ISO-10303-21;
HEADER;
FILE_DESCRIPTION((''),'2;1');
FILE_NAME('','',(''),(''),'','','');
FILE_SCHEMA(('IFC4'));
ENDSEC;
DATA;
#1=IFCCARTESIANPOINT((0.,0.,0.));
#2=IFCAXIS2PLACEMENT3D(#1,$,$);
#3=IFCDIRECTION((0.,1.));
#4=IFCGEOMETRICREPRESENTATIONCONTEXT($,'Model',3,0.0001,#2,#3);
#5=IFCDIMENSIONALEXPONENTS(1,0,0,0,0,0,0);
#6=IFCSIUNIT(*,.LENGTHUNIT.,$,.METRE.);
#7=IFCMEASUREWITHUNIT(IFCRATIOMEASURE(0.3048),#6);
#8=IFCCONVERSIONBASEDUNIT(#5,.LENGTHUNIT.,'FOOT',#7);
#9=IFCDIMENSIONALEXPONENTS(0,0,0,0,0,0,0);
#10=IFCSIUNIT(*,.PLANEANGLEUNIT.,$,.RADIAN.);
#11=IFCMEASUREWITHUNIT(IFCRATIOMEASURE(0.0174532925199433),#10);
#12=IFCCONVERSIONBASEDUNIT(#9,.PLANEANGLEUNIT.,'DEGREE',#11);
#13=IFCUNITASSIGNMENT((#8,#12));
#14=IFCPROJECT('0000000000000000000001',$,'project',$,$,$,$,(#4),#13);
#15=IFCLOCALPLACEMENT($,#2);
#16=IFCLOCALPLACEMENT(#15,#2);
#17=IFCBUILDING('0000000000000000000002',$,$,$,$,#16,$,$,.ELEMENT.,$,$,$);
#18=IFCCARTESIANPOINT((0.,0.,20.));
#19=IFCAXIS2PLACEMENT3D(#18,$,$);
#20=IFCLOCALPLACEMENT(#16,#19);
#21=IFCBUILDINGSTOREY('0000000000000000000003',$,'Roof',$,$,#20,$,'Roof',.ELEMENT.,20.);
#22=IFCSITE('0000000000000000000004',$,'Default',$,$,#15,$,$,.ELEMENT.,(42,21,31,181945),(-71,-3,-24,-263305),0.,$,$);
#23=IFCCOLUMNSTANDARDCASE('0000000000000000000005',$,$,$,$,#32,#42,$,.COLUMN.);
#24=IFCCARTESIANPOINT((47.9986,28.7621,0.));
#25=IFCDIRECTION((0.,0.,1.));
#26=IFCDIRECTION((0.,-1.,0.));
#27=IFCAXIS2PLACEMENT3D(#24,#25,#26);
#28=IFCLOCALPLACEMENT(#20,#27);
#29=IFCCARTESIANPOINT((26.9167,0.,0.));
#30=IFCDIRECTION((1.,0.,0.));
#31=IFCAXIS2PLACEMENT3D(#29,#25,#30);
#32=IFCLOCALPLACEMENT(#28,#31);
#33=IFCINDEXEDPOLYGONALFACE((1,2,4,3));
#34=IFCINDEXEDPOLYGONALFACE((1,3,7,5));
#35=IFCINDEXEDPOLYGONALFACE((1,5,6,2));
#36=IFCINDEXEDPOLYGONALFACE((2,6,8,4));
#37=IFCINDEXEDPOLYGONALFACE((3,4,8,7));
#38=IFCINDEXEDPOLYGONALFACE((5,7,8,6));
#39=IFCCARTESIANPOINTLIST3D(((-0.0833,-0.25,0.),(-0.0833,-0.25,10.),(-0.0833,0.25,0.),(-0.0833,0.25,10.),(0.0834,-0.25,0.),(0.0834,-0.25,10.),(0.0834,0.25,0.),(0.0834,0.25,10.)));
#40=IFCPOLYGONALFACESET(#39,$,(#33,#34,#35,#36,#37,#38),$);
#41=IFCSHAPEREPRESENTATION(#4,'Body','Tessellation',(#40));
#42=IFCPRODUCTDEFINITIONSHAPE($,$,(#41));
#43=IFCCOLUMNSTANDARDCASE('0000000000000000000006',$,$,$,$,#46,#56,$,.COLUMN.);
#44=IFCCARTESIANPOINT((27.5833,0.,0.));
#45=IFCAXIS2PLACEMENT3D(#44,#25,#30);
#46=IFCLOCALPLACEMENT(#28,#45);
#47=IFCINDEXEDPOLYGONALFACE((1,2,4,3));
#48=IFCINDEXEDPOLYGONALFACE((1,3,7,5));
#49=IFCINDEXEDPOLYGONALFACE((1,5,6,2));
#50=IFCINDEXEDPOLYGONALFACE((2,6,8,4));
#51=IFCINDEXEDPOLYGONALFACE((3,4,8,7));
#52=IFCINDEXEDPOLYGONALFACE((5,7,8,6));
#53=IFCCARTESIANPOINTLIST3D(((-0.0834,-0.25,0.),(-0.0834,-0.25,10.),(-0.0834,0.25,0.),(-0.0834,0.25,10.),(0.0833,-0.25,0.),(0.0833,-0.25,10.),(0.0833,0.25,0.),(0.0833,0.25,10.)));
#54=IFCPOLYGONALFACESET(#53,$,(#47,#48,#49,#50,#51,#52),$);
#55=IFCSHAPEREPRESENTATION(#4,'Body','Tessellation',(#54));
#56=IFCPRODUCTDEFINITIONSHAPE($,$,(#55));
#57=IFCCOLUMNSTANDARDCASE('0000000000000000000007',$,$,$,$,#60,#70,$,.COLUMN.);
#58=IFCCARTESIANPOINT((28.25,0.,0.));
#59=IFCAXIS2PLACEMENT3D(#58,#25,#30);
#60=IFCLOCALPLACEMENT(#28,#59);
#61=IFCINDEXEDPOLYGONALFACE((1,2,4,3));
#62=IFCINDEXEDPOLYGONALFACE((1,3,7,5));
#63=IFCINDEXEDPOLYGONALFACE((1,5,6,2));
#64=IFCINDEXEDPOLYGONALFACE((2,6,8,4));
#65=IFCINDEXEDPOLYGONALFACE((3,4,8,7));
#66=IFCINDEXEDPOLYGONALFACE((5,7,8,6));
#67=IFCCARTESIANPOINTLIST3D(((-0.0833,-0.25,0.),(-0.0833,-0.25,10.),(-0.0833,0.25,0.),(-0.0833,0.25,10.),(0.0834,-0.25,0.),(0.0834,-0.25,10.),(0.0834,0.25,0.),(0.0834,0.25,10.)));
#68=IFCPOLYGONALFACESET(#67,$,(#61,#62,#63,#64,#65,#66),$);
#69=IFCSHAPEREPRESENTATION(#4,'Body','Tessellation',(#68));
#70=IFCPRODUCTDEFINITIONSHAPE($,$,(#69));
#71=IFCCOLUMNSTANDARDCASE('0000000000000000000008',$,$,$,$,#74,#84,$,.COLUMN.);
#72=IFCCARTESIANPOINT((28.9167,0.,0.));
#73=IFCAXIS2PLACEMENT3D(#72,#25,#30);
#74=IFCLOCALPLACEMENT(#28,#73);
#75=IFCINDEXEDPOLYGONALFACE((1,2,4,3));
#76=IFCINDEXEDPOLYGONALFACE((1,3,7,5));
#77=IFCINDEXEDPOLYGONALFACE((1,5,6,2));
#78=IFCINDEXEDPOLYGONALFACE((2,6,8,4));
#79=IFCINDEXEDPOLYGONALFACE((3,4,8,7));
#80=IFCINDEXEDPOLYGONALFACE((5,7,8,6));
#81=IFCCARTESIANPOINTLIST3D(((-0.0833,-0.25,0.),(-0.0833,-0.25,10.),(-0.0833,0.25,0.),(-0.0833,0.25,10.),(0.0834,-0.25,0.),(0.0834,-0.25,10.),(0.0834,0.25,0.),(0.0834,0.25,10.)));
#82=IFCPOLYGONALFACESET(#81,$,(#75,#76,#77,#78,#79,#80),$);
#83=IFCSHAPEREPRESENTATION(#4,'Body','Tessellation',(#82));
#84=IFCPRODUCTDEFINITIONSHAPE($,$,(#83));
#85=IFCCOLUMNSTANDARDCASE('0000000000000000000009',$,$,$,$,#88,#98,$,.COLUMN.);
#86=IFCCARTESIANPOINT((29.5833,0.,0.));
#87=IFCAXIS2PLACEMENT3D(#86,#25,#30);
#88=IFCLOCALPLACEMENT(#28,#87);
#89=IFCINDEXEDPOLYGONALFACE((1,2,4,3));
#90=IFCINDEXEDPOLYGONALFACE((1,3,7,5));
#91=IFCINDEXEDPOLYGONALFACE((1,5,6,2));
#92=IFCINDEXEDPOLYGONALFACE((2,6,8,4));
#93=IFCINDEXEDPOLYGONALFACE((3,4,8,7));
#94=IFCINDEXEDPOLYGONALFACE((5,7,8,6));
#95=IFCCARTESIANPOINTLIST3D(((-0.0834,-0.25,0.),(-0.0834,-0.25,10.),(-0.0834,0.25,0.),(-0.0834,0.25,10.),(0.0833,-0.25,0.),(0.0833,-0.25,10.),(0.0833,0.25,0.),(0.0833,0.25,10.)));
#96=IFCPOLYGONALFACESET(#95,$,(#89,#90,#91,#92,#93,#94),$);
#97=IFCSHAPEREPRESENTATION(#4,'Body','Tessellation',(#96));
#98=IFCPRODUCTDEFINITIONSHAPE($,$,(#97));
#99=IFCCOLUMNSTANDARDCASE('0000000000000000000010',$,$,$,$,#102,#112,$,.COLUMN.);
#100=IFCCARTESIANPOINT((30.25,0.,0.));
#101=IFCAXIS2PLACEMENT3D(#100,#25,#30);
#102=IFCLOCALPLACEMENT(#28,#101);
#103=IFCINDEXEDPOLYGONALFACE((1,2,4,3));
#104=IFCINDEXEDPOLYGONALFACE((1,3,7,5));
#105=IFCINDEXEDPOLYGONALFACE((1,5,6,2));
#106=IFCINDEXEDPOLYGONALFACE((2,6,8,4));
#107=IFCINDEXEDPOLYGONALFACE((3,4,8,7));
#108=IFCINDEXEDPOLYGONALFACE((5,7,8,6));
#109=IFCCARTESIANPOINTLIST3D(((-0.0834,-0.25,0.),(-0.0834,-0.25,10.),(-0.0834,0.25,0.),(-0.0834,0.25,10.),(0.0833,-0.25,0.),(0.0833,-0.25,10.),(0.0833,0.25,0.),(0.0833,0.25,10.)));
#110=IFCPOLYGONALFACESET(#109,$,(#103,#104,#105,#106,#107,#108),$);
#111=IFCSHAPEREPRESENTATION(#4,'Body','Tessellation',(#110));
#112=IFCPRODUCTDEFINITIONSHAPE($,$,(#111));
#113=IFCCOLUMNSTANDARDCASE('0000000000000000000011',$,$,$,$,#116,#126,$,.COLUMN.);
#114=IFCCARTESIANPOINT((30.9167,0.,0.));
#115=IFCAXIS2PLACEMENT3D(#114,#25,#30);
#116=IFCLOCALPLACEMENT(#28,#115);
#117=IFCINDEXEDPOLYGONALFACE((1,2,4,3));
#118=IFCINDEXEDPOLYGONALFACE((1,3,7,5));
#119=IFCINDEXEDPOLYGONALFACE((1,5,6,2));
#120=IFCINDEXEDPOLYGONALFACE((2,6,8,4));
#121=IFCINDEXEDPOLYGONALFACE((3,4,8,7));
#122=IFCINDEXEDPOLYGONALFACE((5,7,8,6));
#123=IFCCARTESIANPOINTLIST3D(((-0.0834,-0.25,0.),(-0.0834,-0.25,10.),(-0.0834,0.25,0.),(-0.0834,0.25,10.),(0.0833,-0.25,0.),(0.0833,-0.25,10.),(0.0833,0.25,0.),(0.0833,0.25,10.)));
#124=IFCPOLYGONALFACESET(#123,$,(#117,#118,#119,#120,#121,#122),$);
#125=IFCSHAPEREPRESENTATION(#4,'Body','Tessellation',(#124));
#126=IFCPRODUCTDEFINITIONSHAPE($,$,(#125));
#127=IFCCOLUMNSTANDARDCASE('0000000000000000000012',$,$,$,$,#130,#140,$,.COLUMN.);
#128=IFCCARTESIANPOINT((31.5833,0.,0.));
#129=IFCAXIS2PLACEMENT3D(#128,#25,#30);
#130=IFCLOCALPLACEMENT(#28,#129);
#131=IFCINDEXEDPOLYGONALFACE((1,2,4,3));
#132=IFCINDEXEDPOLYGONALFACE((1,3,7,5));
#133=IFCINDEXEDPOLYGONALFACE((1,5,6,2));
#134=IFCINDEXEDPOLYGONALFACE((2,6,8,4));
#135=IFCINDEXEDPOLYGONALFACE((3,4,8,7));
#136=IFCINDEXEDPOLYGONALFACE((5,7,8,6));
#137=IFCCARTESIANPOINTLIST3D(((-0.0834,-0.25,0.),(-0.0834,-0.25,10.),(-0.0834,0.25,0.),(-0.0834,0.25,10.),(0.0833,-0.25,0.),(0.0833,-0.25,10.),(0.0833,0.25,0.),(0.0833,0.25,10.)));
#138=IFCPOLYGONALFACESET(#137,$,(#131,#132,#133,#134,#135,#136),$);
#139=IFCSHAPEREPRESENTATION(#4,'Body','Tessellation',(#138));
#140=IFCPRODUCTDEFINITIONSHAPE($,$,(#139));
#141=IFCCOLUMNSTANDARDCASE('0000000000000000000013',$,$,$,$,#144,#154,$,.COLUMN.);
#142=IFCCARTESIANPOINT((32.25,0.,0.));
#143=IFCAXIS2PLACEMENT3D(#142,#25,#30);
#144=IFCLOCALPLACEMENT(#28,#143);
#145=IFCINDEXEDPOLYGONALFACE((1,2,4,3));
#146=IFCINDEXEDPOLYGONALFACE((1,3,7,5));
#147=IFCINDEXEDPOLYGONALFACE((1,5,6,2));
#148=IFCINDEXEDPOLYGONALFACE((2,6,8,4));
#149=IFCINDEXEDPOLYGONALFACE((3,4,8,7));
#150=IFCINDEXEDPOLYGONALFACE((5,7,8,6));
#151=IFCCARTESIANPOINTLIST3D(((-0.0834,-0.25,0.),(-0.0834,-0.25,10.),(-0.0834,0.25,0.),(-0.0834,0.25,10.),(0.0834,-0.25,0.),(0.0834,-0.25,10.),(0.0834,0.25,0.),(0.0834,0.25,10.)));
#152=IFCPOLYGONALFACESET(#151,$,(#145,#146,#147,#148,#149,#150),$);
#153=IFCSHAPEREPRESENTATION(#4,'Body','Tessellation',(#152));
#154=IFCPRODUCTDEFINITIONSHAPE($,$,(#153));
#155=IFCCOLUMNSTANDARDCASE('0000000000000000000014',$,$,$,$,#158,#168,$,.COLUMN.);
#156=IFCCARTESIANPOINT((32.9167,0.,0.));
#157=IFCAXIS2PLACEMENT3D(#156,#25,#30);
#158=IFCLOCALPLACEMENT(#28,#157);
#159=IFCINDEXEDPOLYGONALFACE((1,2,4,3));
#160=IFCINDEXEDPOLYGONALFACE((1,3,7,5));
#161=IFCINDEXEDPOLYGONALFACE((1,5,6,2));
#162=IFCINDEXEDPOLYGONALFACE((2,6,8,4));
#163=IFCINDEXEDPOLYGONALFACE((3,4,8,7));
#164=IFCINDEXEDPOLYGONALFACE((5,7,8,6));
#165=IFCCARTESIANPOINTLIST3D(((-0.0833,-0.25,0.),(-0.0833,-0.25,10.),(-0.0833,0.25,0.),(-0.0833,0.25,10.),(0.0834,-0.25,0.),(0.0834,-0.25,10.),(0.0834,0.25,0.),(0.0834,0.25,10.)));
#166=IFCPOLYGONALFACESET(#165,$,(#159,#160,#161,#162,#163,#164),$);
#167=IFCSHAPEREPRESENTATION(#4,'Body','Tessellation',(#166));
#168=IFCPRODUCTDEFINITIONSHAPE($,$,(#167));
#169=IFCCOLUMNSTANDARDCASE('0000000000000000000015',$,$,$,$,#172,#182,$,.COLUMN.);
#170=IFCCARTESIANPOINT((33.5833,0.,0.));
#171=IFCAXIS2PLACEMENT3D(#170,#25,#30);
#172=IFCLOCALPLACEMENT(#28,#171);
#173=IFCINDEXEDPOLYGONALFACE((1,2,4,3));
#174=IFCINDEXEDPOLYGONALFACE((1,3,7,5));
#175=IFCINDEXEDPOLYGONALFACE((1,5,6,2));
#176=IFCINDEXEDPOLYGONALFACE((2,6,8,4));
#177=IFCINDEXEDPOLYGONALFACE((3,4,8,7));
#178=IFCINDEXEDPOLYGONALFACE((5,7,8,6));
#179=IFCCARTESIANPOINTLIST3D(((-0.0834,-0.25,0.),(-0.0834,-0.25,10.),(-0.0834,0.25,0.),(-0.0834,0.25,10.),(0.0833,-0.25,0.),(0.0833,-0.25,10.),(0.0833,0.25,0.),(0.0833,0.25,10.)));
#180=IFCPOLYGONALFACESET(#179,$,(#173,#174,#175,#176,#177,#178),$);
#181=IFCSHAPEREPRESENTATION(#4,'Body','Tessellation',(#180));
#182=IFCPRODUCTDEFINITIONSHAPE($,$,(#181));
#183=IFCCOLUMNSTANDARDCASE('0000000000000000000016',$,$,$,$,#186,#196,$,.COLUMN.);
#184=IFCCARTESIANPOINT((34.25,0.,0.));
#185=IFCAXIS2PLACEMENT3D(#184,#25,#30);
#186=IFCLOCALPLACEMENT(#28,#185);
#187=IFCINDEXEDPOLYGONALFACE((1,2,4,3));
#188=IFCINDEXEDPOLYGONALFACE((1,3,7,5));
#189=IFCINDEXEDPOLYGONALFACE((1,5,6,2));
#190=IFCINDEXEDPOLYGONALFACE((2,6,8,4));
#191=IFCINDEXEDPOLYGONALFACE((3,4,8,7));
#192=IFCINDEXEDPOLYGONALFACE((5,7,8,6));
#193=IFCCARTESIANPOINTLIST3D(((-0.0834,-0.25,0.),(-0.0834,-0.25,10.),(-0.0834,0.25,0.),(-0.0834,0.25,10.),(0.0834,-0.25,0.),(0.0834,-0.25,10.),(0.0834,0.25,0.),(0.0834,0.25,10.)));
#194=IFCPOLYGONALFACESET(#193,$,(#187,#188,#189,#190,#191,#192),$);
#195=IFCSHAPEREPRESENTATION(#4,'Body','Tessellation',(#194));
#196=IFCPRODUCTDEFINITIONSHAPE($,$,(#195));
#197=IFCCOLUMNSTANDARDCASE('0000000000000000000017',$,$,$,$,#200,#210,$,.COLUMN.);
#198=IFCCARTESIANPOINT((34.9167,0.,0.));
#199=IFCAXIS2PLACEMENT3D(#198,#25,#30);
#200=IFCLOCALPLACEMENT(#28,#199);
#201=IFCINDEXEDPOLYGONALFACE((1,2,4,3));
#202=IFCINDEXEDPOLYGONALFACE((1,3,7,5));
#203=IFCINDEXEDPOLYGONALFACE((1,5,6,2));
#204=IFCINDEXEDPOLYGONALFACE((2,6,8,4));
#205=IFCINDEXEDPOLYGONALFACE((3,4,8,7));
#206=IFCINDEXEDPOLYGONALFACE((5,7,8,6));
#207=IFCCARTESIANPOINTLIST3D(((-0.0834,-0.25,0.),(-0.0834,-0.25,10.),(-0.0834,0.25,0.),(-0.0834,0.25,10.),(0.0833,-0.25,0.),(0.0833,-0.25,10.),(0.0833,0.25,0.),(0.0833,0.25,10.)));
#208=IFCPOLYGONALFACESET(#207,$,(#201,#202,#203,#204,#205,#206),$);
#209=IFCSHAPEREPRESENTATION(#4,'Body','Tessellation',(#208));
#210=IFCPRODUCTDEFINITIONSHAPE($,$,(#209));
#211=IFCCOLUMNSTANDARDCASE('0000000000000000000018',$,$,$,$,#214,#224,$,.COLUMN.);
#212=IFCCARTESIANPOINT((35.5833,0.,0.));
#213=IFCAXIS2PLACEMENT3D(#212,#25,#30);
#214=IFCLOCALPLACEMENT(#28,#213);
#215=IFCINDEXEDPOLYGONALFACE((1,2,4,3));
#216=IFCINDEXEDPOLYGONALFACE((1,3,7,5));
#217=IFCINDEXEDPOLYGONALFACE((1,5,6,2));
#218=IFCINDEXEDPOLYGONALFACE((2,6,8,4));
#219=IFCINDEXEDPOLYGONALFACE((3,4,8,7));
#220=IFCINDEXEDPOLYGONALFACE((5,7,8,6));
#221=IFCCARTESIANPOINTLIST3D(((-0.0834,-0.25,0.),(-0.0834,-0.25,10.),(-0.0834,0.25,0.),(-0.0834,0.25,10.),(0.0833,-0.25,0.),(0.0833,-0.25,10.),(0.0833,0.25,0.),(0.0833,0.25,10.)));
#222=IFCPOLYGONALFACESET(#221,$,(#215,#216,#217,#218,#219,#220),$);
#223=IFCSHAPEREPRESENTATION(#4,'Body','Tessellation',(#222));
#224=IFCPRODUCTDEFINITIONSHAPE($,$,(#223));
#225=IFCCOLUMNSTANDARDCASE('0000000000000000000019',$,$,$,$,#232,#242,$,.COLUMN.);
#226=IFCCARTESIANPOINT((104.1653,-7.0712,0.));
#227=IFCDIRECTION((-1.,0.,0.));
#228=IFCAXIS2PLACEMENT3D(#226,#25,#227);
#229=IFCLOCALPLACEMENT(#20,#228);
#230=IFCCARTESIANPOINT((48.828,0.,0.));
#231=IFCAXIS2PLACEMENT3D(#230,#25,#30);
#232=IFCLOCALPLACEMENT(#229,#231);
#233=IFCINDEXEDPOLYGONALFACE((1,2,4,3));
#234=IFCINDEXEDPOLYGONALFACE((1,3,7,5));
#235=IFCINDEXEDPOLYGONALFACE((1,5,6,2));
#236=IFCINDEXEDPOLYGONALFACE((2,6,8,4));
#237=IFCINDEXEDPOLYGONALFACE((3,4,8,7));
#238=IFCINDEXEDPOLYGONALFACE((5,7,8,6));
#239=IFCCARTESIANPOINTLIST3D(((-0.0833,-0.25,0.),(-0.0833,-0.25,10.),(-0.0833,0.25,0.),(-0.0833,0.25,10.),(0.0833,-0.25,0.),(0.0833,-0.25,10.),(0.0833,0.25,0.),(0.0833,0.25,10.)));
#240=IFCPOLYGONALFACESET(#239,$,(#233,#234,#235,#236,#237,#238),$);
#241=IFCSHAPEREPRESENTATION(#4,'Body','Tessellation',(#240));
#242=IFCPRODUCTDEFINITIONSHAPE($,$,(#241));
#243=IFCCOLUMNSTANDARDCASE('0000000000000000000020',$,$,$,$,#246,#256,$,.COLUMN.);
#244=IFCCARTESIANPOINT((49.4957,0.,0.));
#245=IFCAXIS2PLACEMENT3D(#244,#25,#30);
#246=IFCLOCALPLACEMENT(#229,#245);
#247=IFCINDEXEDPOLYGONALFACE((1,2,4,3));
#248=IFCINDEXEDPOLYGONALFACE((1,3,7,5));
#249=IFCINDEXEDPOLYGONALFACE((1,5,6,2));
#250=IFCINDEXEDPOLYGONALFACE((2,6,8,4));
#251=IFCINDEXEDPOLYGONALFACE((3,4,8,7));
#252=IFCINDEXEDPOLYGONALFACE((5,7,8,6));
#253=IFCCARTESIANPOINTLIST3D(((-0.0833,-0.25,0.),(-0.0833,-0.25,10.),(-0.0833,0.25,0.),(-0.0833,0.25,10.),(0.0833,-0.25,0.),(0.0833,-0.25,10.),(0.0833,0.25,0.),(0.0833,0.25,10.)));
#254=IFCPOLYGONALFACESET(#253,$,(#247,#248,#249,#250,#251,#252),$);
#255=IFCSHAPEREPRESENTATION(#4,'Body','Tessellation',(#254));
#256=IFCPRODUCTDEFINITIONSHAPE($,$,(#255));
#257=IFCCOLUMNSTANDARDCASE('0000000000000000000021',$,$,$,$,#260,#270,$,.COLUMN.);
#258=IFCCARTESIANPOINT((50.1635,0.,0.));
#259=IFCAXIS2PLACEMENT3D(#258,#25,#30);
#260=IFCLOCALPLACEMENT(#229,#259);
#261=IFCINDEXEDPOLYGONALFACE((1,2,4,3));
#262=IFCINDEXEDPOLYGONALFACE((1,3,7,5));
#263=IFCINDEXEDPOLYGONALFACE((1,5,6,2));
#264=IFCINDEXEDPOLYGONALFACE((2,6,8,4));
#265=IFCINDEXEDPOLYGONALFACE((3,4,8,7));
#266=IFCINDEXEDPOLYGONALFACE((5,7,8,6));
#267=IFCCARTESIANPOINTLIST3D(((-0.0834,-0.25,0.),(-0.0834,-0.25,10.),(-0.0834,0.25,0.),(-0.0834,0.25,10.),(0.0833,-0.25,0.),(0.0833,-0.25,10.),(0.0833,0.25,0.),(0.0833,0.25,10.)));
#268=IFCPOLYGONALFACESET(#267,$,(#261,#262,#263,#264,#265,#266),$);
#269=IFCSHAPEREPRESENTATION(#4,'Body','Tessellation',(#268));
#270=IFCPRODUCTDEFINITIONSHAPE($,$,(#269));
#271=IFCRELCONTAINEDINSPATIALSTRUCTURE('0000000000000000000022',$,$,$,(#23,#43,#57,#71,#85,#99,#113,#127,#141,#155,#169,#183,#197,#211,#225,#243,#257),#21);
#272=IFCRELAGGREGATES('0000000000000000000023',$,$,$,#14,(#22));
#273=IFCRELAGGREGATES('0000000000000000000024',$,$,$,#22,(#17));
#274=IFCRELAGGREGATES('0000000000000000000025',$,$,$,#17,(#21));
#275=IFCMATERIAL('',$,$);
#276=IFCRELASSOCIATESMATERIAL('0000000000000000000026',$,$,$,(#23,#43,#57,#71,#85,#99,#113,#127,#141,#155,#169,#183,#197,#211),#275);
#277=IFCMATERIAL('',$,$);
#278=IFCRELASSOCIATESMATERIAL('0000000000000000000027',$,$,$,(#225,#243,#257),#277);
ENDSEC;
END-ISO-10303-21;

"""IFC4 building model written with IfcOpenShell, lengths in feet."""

from ifc_helpers import new_model, entity, si_unit, converted_unit, direction, frame, origin, place, context, project, spatial, rectangle, extrude, material, element, save


model = new_model("IFC4")

# Units and contexts
model_context = context("Model", 3, precision=0.0001, world=origin(), true_north=direction((0.0, 1.0)))
ifc_project = project(units=[converted_unit("LENGTHUNIT", "FOOT", entity("IfcRatioMeasure", 0.3048), si_unit("LENGTHUNIT", "METRE"), dimensions=[1, 0, 0, 0, 0, 0, 0]), converted_unit("PLANEANGLEUNIT", "DEGREE", entity("IfcRatioMeasure", 0.0174532925199433), si_unit("PLANEANGLEUNIT", "RADIAN"), dimensions=[0, 0, 0, 0, 0, 0, 0])], contexts=[model_context])

# Site, building, storey
site_placement = place(None, origin())
site = spatial("IfcSite", under=ifc_project, at=site_placement, Name="Default", CompositionType="ELEMENT", RefLatitude=(42, 21, 31, 181945), RefLongitude=(-71, -3, -24, -263305), RefElevation=0.0)
building_placement = place(site_placement, origin())
building = spatial("IfcBuilding", under=site, at=building_placement, CompositionType="ELEMENT")
storey_placement = place(building_placement, frame((0.0, 0.0, 20.0)))
storey = spatial("IfcBuildingStorey", under=building, at=storey_placement, Name="Roof", LongName="Roof", CompositionType="ELEMENT", Elevation=20.0)

# Columns
ifc_material_1 = material(Name="")
placement_1 = place(storey_placement, frame((47.9986, 28.7621, 0.0), z_axis=(0.0, 0.0, 1.0), x_axis=(0.0, -1.0, 0.0)))
for number, where, z_axis, x_axis in (
    (1, (26.9167, 0.0, 0.0), (0.0, 0.0, 1.0), (1.0, 0.0, 0.0)),
    (2, (27.5833, 0.0, 0.0), (0.0, 0.0, 1.0), (1.0, 0.0, 0.0)),
    (3, (28.25, 0.0, 0.0), (0.0, 0.0, 1.0), (1.0, 0.0, 0.0)),
    (4, (28.9167, 0.0, 0.0), (0.0, 0.0, 1.0), (1.0, 0.0, 0.0)),
    (5, (29.5833, 0.0, 0.0), (0.0, 0.0, 1.0), (1.0, 0.0, 0.0)),
    (6, (30.25, 0.0, 0.0), (0.0, 0.0, 1.0), (1.0, 0.0, 0.0)),
    (7, (30.9167, 0.0, 0.0), (0.0, 0.0, 1.0), (1.0, 0.0, 0.0)),
    (8, (31.5833, 0.0, 0.0), (0.0, 0.0, 1.0), (1.0, 0.0, 0.0)),
    (9, (32.25, 0.0, 0.0), (0.0, 0.0, 1.0), (1.0, 0.0, 0.0)),
    (10, (32.9167, 0.0, 0.0), (0.0, 0.0, 1.0), (1.0, 0.0, 0.0)),
    (11, (33.5833, 0.0, 0.0), (0.0, 0.0, 1.0), (1.0, 0.0, 0.0)),
    (12, (34.25, 0.0, 0.0), (0.0, 0.0, 1.0), (1.0, 0.0, 0.0)),
    (13, (34.9167, 0.0, 0.0), (0.0, 0.0, 1.0), (1.0, 0.0, 0.0)),
    (14, (35.5833, 0.0, 0.0), (0.0, 0.0, 1.0), (1.0, 0.0, 0.0)),
):
    element("IfcColumnStandardCase", number, at=place(placement_1, frame(where, z_axis=z_axis, x_axis=x_axis)), inside=storey, material=ifc_material_1, PredefinedType="COLUMN", context=model_context, shape_type="SweptSolid", body=[
        extrude(rectangle(XDim=0.1667, YDim=0.5), origin(), (0.0, 0.0, 1.0), 10.0),
    ])
ifc_material_2 = material(Name="")
placement_2 = place(storey_placement, frame((104.1653, -7.0712, 0.0), z_axis=(0.0, 0.0, 1.0), x_axis=(-1.0, 0.0, 0.0)))
for number, where, z_axis, x_axis in (
    (15, (48.828, 0.0, 0.0), (0.0, 0.0, 1.0), (1.0, 0.0, 0.0)),
    (16, (49.4957, 0.0, 0.0), (0.0, 0.0, 1.0), (1.0, 0.0, 0.0)),
    (17, (50.1635, 0.0, 0.0), (0.0, 0.0, 1.0), (1.0, 0.0, 0.0)),
):
    element("IfcColumnStandardCase", number, at=place(placement_2, frame(where, z_axis=z_axis, x_axis=x_axis)), inside=storey, material=ifc_material_2, PredefinedType="COLUMN", context=model_context, shape_type="SweptSolid", body=[
        extrude(rectangle(XDim=0.1667, YDim=0.5), origin(), (0.0, 0.0, 1.0), 10.0),
    ])

save(model, "model.ifc")
